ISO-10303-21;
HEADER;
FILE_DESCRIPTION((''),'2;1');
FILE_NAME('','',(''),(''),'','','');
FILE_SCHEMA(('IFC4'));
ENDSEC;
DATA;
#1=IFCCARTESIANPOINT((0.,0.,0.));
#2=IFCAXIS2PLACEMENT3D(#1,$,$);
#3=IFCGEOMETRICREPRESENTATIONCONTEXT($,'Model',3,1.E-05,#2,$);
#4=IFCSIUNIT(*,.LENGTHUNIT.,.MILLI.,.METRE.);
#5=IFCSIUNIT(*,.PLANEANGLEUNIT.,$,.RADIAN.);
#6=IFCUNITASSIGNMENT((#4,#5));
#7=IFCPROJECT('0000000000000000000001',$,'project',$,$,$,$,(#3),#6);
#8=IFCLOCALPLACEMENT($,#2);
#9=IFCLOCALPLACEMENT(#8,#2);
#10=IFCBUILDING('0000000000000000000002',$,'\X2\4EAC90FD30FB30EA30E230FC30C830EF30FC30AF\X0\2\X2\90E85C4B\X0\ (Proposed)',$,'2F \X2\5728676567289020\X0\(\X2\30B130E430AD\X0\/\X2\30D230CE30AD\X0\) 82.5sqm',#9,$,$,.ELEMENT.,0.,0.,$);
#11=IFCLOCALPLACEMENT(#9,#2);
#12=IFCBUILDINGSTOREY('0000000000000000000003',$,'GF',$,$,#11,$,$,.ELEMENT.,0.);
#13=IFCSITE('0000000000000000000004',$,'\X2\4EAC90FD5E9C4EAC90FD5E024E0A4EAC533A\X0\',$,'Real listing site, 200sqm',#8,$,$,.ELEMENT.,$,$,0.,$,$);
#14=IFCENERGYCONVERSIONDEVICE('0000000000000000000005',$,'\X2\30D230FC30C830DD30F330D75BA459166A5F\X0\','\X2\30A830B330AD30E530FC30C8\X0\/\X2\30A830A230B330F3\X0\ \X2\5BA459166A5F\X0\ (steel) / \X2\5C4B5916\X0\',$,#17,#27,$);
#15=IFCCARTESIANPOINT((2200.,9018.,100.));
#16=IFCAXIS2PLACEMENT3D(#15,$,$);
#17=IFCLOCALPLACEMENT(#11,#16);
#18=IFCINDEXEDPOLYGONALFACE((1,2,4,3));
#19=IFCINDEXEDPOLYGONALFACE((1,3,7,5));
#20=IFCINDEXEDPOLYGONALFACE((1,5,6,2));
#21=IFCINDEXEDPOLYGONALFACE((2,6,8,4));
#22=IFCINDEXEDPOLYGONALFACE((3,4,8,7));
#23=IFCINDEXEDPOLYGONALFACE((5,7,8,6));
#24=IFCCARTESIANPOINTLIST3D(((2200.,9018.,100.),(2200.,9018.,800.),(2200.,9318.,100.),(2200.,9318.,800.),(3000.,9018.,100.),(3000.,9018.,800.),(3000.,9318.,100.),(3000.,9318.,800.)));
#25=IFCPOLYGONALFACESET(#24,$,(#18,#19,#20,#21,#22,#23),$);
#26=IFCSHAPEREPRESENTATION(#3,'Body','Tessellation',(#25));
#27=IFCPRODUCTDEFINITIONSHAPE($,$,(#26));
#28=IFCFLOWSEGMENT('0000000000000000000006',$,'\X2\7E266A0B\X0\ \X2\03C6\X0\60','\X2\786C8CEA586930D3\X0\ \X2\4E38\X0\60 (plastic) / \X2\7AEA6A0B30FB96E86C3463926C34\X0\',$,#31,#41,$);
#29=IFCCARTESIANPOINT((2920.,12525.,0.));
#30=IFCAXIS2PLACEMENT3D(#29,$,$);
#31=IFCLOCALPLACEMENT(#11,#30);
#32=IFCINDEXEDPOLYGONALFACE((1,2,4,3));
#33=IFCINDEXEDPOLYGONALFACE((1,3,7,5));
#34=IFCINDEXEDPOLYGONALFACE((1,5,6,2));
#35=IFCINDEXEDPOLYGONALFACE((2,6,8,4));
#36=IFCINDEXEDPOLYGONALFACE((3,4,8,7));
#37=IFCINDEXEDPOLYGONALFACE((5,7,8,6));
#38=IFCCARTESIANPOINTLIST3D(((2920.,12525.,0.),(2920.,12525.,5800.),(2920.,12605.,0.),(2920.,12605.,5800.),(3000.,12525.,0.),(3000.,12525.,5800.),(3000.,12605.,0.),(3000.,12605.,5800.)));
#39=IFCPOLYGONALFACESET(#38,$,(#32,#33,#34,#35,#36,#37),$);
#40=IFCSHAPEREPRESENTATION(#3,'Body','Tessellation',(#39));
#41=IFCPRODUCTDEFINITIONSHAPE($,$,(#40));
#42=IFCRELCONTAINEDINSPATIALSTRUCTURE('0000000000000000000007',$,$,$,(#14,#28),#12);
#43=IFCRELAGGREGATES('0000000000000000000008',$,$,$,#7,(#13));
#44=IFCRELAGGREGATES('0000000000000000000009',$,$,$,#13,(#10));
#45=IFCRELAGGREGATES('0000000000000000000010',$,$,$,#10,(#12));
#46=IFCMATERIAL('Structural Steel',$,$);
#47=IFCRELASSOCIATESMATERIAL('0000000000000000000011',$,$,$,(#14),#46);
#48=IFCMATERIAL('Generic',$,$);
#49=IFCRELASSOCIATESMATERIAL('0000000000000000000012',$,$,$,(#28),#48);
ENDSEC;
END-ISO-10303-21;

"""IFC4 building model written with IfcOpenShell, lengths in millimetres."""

from ifc_helpers import new_model, si_unit, frame, frame_2d, origin, place, context, project, spatial, rectangle, extrude, material, element, save


model = new_model("IFC4")

# Units and contexts
model_context = context("Model", 3, precision=1e-05, world=origin())
ifc_project = project(units=[si_unit("LENGTHUNIT", "METRE", prefix="MILLI"), si_unit("PLANEANGLEUNIT", "RADIAN")], contexts=[model_context])

# Site, building, storey
site_placement = place(None, origin())
site = spatial("IfcSite", under=ifc_project, at=site_placement, Name="京都府京都市上京区", ObjectType="Real listing site, 200sqm", CompositionType="ELEMENT", RefElevation=0.0)
building_placement = place(site_placement, origin())
building = spatial("IfcBuilding", under=site, at=building_placement, Name="京都・リモートワーク2部屋 (Proposed)", ObjectType="2F 在来木造(ケヤキ/ヒノキ) 82.5sqm", CompositionType="ELEMENT", ElevationOfRefHeight=0.0, ElevationOfTerrain=0.0)
storey_placement = place(building_placement, origin())
storey = spatial("IfcBuildingStorey", under=building, at=storey_placement, Name="GF", CompositionType="ELEMENT", Elevation=0.0)

# Shared definitions
ifc_material_1 = material(Name="Generic")

# Energy conversion device
ifc_material_2 = material(Name="Structural Steel")
energy_conversion_device_placement = place(storey_placement, frame((2200.0, 9018.0, 100.0)))
element("IfcEnergyConversionDevice", 1, at=energy_conversion_device_placement, inside=storey, material=ifc_material_2, Name="ヒートポンプ室外機", Description="エコキュート/エアコン 室外機 (steel) / 屋外", context=model_context, shape_type="SweptSolid", body=[
    extrude(rectangle(XDim=800.0, YDim=300.0, at=frame_2d((400.0, 150.0))), frame((2200.0, 9018.0, 100.0)), (0.0, 0.0, 1.0), 700.0),
])

# Flow segment
flow_segment_placement = place(storey_placement, frame((2920.0, 12525.0, 0.0)))
element("IfcFlowSegment", 2, at=flow_segment_placement, inside=storey, material=ifc_material_1, Name="縦樋 φ60", Description="硬質塩ビ 丸60 (plastic) / 竪樋・雨水排水", context=model_context, shape_type="SweptSolid", body=[
    extrude(rectangle(XDim=80.0, YDim=80.0, at=frame_2d((40.0, 40.0))), frame((2920.0, 12525.0, 0.0)), (0.0, 0.0, 1.0), 5800.0),
])

save(model, "model.ifc")
